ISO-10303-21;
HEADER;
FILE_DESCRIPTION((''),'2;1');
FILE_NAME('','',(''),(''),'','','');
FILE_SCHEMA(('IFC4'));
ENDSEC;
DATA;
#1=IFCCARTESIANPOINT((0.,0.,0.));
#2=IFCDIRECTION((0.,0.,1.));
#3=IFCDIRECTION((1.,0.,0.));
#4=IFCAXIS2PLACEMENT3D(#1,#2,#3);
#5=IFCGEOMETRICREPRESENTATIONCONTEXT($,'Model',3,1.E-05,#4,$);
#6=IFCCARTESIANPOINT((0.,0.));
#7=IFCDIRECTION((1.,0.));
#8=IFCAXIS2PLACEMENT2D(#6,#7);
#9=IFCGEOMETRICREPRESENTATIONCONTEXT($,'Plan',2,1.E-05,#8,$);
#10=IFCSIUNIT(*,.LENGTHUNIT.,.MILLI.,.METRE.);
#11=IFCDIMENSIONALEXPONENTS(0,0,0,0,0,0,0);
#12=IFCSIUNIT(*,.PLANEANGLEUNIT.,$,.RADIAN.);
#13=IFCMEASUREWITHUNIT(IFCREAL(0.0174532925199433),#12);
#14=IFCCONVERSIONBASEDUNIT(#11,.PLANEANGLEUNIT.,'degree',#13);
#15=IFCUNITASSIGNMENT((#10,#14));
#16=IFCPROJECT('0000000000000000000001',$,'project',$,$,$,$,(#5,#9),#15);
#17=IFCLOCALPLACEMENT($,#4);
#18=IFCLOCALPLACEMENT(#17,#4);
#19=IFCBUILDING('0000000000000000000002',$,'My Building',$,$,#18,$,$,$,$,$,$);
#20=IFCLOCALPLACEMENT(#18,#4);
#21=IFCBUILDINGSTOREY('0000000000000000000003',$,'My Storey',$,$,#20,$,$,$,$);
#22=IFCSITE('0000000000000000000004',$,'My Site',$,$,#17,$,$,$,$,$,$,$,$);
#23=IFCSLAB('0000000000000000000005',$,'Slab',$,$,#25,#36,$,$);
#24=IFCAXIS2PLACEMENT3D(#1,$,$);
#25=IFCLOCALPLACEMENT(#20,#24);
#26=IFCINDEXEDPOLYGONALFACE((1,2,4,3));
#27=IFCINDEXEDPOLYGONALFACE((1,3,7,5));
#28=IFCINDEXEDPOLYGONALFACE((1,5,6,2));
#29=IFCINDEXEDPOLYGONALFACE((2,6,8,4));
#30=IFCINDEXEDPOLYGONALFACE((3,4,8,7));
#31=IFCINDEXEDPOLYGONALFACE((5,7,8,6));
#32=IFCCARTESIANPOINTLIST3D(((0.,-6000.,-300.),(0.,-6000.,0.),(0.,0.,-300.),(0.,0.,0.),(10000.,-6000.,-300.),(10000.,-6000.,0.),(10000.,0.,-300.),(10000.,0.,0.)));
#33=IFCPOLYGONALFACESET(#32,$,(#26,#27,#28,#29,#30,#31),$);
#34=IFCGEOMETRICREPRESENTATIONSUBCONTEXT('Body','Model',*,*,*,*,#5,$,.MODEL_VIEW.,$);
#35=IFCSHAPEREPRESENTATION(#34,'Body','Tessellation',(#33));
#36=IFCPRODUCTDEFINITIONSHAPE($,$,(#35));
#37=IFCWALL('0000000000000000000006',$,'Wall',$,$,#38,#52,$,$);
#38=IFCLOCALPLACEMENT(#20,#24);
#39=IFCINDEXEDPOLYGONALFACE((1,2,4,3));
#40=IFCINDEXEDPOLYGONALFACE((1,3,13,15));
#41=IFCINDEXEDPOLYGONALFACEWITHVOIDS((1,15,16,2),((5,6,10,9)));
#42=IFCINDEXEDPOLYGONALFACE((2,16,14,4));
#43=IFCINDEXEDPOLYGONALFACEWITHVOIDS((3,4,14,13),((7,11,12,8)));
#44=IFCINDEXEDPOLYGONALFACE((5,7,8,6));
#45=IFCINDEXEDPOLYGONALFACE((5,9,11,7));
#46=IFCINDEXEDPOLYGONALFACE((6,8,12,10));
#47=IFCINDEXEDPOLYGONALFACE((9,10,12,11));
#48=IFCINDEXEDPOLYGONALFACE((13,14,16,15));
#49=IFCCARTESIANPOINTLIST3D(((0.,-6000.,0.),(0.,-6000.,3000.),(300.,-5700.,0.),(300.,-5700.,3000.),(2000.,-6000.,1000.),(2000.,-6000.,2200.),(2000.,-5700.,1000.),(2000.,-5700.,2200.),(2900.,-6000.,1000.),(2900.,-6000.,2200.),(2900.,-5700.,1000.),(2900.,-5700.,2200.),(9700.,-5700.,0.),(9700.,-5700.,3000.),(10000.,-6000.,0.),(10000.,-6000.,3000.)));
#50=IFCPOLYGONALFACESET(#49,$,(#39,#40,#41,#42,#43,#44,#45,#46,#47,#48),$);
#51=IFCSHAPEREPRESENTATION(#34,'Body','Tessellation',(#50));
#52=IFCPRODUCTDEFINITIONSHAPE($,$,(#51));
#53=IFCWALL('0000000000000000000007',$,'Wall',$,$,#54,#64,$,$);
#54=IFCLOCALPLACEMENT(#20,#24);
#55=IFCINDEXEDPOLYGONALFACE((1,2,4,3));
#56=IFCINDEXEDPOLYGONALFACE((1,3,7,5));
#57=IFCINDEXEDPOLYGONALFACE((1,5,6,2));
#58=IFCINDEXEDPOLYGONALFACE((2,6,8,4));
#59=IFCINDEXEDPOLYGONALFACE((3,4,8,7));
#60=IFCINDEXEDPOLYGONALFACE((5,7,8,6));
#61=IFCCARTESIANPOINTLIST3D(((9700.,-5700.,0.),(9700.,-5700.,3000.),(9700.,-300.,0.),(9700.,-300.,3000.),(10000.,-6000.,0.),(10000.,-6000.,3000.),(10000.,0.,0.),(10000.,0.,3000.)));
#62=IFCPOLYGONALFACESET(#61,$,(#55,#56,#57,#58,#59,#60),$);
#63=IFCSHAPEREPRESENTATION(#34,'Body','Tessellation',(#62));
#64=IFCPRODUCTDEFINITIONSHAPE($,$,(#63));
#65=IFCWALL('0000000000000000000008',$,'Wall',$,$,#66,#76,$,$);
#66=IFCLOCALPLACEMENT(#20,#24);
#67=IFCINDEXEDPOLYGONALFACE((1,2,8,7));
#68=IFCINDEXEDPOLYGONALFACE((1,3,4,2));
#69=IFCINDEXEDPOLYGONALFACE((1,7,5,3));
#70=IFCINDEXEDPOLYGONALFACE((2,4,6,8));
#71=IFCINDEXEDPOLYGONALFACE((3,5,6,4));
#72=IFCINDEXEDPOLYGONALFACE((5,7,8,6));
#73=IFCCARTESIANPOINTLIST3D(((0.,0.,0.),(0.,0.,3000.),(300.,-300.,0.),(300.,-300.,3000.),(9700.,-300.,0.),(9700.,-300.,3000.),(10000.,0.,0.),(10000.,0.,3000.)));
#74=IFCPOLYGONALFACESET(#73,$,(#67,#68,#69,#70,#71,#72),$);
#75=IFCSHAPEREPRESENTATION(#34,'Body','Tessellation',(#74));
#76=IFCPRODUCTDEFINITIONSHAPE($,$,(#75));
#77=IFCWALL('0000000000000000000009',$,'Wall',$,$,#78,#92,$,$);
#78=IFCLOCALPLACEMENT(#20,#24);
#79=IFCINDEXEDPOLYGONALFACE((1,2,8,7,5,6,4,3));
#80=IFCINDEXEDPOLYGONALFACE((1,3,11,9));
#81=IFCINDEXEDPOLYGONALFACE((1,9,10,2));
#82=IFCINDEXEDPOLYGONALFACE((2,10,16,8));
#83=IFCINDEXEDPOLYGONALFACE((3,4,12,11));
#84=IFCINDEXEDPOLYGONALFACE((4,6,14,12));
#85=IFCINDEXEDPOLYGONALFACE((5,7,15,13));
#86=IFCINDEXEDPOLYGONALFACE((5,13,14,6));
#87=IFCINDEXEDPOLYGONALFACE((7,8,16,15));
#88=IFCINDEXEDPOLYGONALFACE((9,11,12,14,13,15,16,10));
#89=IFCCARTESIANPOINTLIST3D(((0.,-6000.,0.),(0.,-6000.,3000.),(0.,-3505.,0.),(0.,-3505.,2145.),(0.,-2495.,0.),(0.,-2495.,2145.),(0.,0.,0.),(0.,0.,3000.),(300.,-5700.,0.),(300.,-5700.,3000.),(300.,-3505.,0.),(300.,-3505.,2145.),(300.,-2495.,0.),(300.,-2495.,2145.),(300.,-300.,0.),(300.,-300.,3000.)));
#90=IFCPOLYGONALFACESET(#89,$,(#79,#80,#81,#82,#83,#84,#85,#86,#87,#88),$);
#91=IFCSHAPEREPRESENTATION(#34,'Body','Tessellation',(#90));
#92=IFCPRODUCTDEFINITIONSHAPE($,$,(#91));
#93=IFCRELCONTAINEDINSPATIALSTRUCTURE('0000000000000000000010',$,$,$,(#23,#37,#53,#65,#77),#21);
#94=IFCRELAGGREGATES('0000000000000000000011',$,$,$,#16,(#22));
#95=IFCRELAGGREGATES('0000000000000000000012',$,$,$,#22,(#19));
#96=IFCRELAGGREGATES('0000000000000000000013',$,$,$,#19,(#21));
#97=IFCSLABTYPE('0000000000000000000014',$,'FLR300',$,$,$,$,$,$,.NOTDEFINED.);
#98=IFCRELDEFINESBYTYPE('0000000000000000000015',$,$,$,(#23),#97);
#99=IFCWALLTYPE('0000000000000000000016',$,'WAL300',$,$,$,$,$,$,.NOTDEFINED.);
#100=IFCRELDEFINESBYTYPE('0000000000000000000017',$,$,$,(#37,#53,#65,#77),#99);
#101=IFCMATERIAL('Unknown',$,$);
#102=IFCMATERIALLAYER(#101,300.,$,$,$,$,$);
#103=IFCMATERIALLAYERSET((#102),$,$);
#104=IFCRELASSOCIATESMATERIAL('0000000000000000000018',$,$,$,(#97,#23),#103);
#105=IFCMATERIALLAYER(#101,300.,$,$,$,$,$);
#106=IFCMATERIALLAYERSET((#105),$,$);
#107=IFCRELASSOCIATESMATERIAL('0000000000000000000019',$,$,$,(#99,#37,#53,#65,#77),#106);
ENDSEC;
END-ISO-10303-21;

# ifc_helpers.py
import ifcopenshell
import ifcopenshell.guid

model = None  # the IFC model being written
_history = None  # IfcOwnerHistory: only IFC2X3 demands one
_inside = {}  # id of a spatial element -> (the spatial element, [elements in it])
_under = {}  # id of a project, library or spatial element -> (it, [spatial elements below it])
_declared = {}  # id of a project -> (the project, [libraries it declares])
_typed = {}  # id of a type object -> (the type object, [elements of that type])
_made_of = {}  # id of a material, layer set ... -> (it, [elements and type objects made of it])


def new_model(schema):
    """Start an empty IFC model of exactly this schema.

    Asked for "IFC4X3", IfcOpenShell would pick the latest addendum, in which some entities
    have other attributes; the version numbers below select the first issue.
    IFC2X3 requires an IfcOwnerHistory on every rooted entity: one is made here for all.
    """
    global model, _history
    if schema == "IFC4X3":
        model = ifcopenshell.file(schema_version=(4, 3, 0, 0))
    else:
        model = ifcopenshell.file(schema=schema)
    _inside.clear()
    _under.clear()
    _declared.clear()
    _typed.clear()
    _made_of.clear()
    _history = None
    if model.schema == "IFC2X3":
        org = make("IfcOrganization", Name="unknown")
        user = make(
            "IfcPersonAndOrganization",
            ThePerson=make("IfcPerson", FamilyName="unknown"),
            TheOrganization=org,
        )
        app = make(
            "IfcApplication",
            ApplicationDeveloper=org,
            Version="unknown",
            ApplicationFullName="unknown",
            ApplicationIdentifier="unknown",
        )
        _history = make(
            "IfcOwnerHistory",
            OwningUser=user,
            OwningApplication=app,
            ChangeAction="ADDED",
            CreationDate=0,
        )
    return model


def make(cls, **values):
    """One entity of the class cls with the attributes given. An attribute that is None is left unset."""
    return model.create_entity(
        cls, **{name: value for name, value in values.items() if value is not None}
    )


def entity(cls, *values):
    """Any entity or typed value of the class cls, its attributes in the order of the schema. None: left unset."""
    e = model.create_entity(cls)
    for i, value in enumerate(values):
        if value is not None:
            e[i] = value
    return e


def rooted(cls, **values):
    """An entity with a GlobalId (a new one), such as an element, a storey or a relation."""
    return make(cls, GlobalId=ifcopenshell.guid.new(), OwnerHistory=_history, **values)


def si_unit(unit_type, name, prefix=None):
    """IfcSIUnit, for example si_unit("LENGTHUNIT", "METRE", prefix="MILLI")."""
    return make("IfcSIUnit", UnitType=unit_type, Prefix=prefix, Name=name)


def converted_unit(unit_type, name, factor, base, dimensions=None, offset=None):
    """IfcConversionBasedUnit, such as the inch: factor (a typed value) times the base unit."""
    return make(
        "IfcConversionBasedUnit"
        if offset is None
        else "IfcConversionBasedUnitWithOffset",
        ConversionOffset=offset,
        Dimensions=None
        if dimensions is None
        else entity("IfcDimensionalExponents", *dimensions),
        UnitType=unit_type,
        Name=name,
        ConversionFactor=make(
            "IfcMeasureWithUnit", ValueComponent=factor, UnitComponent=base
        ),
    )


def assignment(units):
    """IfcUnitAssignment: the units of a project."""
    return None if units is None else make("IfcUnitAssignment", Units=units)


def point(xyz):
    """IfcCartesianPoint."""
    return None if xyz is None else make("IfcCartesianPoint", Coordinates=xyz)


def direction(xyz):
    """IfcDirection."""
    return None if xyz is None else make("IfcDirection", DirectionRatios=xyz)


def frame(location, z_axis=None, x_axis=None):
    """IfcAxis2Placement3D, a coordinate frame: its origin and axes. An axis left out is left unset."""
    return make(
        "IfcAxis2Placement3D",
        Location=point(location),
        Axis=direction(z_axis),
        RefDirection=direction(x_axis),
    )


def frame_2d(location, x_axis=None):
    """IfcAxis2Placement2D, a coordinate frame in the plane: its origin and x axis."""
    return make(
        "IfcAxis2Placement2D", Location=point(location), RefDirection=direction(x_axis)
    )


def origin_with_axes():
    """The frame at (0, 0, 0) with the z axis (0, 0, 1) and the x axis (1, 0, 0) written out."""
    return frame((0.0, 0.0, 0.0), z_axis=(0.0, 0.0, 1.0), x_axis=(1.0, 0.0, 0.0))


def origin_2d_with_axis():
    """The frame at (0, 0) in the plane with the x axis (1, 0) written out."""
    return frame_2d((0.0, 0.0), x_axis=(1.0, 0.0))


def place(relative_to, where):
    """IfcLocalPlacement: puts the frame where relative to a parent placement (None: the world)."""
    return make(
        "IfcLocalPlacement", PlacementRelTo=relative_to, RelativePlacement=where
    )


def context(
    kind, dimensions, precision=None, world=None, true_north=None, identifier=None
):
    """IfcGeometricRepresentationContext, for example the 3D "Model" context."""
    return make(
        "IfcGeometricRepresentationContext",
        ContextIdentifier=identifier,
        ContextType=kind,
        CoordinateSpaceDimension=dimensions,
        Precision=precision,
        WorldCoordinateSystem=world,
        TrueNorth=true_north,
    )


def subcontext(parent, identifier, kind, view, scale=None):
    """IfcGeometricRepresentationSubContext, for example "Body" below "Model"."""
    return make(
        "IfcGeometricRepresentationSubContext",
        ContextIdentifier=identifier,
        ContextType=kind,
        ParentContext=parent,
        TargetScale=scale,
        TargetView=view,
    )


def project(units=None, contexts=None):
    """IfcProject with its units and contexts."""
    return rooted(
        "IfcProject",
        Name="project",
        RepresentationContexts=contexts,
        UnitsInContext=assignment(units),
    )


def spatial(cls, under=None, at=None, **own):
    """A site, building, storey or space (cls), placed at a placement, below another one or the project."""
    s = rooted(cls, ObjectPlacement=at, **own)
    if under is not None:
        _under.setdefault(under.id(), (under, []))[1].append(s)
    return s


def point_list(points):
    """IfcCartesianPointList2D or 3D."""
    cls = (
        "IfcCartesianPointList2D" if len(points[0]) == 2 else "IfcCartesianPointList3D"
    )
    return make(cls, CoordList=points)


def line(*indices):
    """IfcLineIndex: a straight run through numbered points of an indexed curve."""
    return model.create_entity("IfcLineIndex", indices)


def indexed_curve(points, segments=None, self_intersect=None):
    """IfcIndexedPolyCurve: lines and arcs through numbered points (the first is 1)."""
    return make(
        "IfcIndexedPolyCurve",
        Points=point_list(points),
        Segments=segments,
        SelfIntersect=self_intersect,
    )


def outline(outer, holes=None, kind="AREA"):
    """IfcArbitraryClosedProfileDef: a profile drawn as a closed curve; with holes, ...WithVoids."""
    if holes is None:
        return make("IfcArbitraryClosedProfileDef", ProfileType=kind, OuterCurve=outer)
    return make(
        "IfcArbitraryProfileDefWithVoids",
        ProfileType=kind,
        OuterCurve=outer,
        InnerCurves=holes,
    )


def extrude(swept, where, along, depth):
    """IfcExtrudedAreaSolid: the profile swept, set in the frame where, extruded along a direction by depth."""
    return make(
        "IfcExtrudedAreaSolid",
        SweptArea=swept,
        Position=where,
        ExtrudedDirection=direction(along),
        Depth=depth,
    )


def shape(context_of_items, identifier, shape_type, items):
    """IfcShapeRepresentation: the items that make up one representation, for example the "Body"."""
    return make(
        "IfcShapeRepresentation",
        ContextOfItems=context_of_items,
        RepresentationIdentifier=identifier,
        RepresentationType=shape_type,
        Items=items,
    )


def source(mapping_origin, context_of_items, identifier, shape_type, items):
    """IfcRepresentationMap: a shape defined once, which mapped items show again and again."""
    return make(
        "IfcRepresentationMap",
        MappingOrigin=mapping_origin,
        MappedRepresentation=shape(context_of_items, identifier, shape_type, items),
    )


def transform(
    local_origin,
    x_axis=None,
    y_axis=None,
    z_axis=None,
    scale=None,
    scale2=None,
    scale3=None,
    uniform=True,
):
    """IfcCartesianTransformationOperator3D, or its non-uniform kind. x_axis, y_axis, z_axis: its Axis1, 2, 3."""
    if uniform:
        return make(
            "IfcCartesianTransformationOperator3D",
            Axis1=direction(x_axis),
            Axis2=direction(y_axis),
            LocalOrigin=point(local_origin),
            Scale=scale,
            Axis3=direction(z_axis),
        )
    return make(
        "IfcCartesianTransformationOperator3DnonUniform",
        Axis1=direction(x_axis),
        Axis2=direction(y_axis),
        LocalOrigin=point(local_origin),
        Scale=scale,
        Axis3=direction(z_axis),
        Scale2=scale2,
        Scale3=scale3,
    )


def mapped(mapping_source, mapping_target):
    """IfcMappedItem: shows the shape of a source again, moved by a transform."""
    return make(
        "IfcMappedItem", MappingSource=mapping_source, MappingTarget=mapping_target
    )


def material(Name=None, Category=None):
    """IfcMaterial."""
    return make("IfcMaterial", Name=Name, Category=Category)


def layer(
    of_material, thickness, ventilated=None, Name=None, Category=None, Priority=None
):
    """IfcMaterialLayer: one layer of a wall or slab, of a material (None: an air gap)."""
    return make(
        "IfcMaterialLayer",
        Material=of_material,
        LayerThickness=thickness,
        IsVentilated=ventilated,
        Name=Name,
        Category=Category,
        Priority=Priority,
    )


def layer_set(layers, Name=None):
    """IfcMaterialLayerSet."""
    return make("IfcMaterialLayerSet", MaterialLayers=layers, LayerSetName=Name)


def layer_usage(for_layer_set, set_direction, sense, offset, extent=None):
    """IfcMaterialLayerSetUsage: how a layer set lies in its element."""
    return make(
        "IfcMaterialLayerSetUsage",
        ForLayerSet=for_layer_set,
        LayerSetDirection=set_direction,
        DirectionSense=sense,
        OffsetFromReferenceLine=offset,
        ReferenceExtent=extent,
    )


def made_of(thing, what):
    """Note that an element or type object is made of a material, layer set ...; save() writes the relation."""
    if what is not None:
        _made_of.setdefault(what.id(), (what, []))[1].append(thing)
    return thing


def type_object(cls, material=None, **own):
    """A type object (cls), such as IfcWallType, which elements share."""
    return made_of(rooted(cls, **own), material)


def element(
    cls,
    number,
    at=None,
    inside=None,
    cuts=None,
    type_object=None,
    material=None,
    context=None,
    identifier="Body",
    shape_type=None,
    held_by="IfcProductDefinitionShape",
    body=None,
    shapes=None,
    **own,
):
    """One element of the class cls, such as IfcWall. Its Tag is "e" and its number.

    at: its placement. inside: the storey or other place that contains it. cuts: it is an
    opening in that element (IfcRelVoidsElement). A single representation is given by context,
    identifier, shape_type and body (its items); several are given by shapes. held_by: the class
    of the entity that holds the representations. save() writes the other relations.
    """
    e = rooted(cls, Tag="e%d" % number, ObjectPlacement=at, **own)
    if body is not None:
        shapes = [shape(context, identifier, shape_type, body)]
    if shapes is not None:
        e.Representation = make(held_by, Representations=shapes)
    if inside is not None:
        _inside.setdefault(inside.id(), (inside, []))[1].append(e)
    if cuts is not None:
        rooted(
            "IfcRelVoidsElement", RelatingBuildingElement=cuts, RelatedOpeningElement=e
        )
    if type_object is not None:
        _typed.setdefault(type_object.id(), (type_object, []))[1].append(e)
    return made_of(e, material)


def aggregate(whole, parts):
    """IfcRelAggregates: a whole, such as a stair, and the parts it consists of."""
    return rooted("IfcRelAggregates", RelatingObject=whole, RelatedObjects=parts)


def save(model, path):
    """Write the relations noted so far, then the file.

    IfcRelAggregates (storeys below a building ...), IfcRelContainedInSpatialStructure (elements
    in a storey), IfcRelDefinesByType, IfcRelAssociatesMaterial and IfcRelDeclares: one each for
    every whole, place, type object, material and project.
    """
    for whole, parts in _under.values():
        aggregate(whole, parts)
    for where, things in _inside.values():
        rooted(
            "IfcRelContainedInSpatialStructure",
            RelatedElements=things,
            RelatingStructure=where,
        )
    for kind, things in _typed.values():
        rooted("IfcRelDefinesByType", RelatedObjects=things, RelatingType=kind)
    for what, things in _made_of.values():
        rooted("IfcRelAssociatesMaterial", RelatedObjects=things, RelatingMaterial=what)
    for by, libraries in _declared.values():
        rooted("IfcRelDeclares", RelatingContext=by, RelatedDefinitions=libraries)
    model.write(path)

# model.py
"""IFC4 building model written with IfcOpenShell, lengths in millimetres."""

from ifc_helpers import new_model, entity, si_unit, converted_unit, frame, origin_with_axes, origin_2d_with_axis, place, context, subcontext, project, spatial, line, indexed_curve, outline, extrude, source, transform, mapped, material, layer, layer_set, layer_usage, type_object, element, save


model = new_model("IFC4")

# Units and contexts
model_context = context("Model", 3, precision=1e-05, world=origin_with_axes())
plan_context = context("Plan", 2, precision=1e-05, world=origin_2d_with_axis())
body_context = subcontext(model_context, "Body", "Model", "MODEL_VIEW")
ifc_project = project(units=[si_unit("LENGTHUNIT", "METRE", prefix="MILLI"), converted_unit("PLANEANGLEUNIT", "degree", entity("IfcReal", 0.0174532925199433), si_unit("PLANEANGLEUNIT", "RADIAN"), dimensions=[0, 0, 0, 0, 0, 0, 0])], contexts=[model_context, plan_context])

# Site, building, storey
site_placement = place(None, origin_with_axes())
site = spatial("IfcSite", under=ifc_project, at=site_placement, Name="My Site")
building_placement = place(site_placement, origin_with_axes())
building = spatial("IfcBuilding", under=site, at=building_placement, Name="My Building")
storey_placement = place(building_placement, origin_with_axes())
storey = spatial("IfcBuildingStorey", under=building, at=storey_placement, Name="My Storey")

# Slab
ifc_material = material(Name="Unknown")
ifc_layer_1 = layer(ifc_material, 300.0)
ifc_layer_set_1 = layer_set([ifc_layer_1])
ifc_layer_usage_1 = layer_usage(ifc_layer_set_1, "AXIS3", "POSITIVE", -300.0)
slab_type = type_object("IfcSlabType", Name="FLR300", PredefinedType="NOTDEFINED", material=ifc_layer_set_1)
slab_placement = place(storey_placement, origin_with_axes())
element("IfcSlab", 1, at=slab_placement, inside=storey, type_object=slab_type, material=ifc_layer_usage_1, Name="Slab", context=body_context, shape_type="SweptSolid", body=[
    extrude(outline(indexed_curve([(0.0, 0.0), (0.0, -6000.0), (10000.0, -6000.0), (10000.0, 0.0), (0.0, 0.0)])), frame((0.0, 0.0, -300.0), z_axis=(0.0, 0.0, 1.0), x_axis=(1.0, 0.0, 0.0)), (0.0, 0.0, 1.0), 300.0),
])

# Wall, opening
ifc_layer_2 = layer(ifc_material, 300.0)
ifc_layer_set_2 = layer_set([ifc_layer_2])
ifc_layer_usage_2 = layer_usage(ifc_layer_set_2, "AXIS2", "POSITIVE", 0.0)
wall_type = type_object("IfcWallType", Name="WAL300", PredefinedType="NOTDEFINED", material=ifc_layer_set_2)
wall_1_placement = place(storey_placement, frame((0.0, -6000.0, 0.0), z_axis=(0.0, 0.0, 1.0), x_axis=(1.0, 0.0, 0.0)))
wall_1 = element("IfcWall", 2, at=wall_1_placement, inside=storey, type_object=wall_type, material=ifc_layer_usage_2, Name="Wall", context=body_context, shape_type="SweptSolid", body=[
    extrude(outline(indexed_curve([(0.0, 0.0), (300.0, 300.0), (9700.0, 300.0), (10000.0, 0.0)], segments=[line(1, 2, 3, 4, 1)])), origin_with_axes(), (0.0, 0.0, 1.0), 3000.0),
])
shared_shape_1 = source(origin_with_axes(), body_context, "Body", "SweptSolid", [
    extrude(outline(indexed_curve([(0.0, 0.0), (900.0, 0.0), (900.0, 1200.0), (0.0, 1200.0)], segments=[line(1, 2, 3, 4, 1)])), frame((0.0, -600.0, 0.0), z_axis=(0.0, -1.0, 0.0), x_axis=(1.0, 0.0, 0.0)), (0.0, 0.0, -1.0), 1200.0),
])
opening_1_placement = place(wall_1_placement, frame((2000.0, 0.0, 1000.0), z_axis=(0.0, 0.0, 1.0), x_axis=(1.0, 0.0, 0.0)))
element("IfcOpeningElement", 3, at=opening_1_placement, cuts=wall_1, PredefinedType="OPENING", context=body_context, shape_type="MappedRepresentation", body=[
    mapped(shared_shape_1, transform((0.0, 0.0, 0.0), x_axis=(1.0, 0.0, 0.0), y_axis=(0.0, 1.0, 0.0), z_axis=(0.0, 0.0, 1.0), scale=1.0)),
])

# Walls
ifc_layer_usage_3 = layer_usage(ifc_layer_set_2, "AXIS2", "POSITIVE", 0.0)
wall_2_placement = place(storey_placement, frame((10000.0, -6000.0, 0.0), z_axis=(0.0, 0.0, 1.0), x_axis=(0.0, 1.0, 0.0)))
element("IfcWall", 4, at=wall_2_placement, inside=storey, type_object=wall_type, material=ifc_layer_usage_3, Name="Wall", context=body_context, shape_type="SweptSolid", body=[
    extrude(outline(indexed_curve([(0.0, 0.0), (300.0, 300.0), (5700.0, 300.0), (6000.0, 0.0)], segments=[line(1, 2, 3, 4, 1)])), origin_with_axes(), (0.0, 0.0, 1.0), 3000.0),
])
ifc_layer_usage_4 = layer_usage(ifc_layer_set_2, "AXIS2", "POSITIVE", 0.0)
wall_3_placement = place(storey_placement, frame((10000.0, 0.0, 0.0), z_axis=(0.0, 0.0, 1.0), x_axis=(-1.0, 0.0, 0.0)))
element("IfcWall", 5, at=wall_3_placement, inside=storey, type_object=wall_type, material=ifc_layer_usage_4, Name="Wall", context=body_context, shape_type="SweptSolid", body=[
    extrude(outline(indexed_curve([(0.0, 0.0), (300.0, 300.0), (9700.0, 300.0), (10000.0, 0.0)], segments=[line(1, 2, 3, 4, 1)])), origin_with_axes(), (0.0, 0.0, 1.0), 3000.0),
])

# Wall, opening
ifc_layer_usage_5 = layer_usage(ifc_layer_set_2, "AXIS2", "POSITIVE", 0.0)
wall_4_placement = place(storey_placement, frame((0.0, 0.0, 0.0), z_axis=(0.0, 0.0, 1.0), x_axis=(0.0, -1.0, 0.0)))
wall_4 = element("IfcWall", 6, at=wall_4_placement, inside=storey, type_object=wall_type, material=ifc_layer_usage_5, Name="Wall", context=body_context, shape_type="SweptSolid", body=[
    extrude(outline(indexed_curve([(0.0, 0.0), (300.0, 300.0), (5700.0, 300.0), (6000.0, 0.0)], segments=[line(1, 2, 3, 4, 1)])), origin_with_axes(), (0.0, 0.0, 1.0), 3000.0),
])
shared_shape_2 = source(origin_with_axes(), body_context, "Body", "SweptSolid", [
    extrude(outline(indexed_curve([(0.0, 0.0), (1010.0, 0.0), (1010.0, 2145.0), (0.0, 2145.0)], segments=[line(1, 2, 3, 4, 1)])), frame((0.0, -600.0, 0.0), z_axis=(0.0, -1.0, 0.0), x_axis=(1.0, 0.0, 0.0)), (0.0, 0.0, -1.0), 1200.0),
])
opening_2_placement = place(wall_4_placement, frame((2495.0, 0.0, 0.0), z_axis=(0.0, 0.0, 1.0), x_axis=(1.0, 0.0, 0.0)))
element("IfcOpeningElement", 7, at=opening_2_placement, cuts=wall_4, PredefinedType="OPENING", context=body_context, shape_type="MappedRepresentation", body=[
    mapped(shared_shape_2, transform((0.0, 0.0, 0.0), x_axis=(1.0, 0.0, 0.0), y_axis=(0.0, 1.0, 0.0), z_axis=(0.0, 0.0, 1.0), scale=1.0)),
])

save(model, "model.ifc")
